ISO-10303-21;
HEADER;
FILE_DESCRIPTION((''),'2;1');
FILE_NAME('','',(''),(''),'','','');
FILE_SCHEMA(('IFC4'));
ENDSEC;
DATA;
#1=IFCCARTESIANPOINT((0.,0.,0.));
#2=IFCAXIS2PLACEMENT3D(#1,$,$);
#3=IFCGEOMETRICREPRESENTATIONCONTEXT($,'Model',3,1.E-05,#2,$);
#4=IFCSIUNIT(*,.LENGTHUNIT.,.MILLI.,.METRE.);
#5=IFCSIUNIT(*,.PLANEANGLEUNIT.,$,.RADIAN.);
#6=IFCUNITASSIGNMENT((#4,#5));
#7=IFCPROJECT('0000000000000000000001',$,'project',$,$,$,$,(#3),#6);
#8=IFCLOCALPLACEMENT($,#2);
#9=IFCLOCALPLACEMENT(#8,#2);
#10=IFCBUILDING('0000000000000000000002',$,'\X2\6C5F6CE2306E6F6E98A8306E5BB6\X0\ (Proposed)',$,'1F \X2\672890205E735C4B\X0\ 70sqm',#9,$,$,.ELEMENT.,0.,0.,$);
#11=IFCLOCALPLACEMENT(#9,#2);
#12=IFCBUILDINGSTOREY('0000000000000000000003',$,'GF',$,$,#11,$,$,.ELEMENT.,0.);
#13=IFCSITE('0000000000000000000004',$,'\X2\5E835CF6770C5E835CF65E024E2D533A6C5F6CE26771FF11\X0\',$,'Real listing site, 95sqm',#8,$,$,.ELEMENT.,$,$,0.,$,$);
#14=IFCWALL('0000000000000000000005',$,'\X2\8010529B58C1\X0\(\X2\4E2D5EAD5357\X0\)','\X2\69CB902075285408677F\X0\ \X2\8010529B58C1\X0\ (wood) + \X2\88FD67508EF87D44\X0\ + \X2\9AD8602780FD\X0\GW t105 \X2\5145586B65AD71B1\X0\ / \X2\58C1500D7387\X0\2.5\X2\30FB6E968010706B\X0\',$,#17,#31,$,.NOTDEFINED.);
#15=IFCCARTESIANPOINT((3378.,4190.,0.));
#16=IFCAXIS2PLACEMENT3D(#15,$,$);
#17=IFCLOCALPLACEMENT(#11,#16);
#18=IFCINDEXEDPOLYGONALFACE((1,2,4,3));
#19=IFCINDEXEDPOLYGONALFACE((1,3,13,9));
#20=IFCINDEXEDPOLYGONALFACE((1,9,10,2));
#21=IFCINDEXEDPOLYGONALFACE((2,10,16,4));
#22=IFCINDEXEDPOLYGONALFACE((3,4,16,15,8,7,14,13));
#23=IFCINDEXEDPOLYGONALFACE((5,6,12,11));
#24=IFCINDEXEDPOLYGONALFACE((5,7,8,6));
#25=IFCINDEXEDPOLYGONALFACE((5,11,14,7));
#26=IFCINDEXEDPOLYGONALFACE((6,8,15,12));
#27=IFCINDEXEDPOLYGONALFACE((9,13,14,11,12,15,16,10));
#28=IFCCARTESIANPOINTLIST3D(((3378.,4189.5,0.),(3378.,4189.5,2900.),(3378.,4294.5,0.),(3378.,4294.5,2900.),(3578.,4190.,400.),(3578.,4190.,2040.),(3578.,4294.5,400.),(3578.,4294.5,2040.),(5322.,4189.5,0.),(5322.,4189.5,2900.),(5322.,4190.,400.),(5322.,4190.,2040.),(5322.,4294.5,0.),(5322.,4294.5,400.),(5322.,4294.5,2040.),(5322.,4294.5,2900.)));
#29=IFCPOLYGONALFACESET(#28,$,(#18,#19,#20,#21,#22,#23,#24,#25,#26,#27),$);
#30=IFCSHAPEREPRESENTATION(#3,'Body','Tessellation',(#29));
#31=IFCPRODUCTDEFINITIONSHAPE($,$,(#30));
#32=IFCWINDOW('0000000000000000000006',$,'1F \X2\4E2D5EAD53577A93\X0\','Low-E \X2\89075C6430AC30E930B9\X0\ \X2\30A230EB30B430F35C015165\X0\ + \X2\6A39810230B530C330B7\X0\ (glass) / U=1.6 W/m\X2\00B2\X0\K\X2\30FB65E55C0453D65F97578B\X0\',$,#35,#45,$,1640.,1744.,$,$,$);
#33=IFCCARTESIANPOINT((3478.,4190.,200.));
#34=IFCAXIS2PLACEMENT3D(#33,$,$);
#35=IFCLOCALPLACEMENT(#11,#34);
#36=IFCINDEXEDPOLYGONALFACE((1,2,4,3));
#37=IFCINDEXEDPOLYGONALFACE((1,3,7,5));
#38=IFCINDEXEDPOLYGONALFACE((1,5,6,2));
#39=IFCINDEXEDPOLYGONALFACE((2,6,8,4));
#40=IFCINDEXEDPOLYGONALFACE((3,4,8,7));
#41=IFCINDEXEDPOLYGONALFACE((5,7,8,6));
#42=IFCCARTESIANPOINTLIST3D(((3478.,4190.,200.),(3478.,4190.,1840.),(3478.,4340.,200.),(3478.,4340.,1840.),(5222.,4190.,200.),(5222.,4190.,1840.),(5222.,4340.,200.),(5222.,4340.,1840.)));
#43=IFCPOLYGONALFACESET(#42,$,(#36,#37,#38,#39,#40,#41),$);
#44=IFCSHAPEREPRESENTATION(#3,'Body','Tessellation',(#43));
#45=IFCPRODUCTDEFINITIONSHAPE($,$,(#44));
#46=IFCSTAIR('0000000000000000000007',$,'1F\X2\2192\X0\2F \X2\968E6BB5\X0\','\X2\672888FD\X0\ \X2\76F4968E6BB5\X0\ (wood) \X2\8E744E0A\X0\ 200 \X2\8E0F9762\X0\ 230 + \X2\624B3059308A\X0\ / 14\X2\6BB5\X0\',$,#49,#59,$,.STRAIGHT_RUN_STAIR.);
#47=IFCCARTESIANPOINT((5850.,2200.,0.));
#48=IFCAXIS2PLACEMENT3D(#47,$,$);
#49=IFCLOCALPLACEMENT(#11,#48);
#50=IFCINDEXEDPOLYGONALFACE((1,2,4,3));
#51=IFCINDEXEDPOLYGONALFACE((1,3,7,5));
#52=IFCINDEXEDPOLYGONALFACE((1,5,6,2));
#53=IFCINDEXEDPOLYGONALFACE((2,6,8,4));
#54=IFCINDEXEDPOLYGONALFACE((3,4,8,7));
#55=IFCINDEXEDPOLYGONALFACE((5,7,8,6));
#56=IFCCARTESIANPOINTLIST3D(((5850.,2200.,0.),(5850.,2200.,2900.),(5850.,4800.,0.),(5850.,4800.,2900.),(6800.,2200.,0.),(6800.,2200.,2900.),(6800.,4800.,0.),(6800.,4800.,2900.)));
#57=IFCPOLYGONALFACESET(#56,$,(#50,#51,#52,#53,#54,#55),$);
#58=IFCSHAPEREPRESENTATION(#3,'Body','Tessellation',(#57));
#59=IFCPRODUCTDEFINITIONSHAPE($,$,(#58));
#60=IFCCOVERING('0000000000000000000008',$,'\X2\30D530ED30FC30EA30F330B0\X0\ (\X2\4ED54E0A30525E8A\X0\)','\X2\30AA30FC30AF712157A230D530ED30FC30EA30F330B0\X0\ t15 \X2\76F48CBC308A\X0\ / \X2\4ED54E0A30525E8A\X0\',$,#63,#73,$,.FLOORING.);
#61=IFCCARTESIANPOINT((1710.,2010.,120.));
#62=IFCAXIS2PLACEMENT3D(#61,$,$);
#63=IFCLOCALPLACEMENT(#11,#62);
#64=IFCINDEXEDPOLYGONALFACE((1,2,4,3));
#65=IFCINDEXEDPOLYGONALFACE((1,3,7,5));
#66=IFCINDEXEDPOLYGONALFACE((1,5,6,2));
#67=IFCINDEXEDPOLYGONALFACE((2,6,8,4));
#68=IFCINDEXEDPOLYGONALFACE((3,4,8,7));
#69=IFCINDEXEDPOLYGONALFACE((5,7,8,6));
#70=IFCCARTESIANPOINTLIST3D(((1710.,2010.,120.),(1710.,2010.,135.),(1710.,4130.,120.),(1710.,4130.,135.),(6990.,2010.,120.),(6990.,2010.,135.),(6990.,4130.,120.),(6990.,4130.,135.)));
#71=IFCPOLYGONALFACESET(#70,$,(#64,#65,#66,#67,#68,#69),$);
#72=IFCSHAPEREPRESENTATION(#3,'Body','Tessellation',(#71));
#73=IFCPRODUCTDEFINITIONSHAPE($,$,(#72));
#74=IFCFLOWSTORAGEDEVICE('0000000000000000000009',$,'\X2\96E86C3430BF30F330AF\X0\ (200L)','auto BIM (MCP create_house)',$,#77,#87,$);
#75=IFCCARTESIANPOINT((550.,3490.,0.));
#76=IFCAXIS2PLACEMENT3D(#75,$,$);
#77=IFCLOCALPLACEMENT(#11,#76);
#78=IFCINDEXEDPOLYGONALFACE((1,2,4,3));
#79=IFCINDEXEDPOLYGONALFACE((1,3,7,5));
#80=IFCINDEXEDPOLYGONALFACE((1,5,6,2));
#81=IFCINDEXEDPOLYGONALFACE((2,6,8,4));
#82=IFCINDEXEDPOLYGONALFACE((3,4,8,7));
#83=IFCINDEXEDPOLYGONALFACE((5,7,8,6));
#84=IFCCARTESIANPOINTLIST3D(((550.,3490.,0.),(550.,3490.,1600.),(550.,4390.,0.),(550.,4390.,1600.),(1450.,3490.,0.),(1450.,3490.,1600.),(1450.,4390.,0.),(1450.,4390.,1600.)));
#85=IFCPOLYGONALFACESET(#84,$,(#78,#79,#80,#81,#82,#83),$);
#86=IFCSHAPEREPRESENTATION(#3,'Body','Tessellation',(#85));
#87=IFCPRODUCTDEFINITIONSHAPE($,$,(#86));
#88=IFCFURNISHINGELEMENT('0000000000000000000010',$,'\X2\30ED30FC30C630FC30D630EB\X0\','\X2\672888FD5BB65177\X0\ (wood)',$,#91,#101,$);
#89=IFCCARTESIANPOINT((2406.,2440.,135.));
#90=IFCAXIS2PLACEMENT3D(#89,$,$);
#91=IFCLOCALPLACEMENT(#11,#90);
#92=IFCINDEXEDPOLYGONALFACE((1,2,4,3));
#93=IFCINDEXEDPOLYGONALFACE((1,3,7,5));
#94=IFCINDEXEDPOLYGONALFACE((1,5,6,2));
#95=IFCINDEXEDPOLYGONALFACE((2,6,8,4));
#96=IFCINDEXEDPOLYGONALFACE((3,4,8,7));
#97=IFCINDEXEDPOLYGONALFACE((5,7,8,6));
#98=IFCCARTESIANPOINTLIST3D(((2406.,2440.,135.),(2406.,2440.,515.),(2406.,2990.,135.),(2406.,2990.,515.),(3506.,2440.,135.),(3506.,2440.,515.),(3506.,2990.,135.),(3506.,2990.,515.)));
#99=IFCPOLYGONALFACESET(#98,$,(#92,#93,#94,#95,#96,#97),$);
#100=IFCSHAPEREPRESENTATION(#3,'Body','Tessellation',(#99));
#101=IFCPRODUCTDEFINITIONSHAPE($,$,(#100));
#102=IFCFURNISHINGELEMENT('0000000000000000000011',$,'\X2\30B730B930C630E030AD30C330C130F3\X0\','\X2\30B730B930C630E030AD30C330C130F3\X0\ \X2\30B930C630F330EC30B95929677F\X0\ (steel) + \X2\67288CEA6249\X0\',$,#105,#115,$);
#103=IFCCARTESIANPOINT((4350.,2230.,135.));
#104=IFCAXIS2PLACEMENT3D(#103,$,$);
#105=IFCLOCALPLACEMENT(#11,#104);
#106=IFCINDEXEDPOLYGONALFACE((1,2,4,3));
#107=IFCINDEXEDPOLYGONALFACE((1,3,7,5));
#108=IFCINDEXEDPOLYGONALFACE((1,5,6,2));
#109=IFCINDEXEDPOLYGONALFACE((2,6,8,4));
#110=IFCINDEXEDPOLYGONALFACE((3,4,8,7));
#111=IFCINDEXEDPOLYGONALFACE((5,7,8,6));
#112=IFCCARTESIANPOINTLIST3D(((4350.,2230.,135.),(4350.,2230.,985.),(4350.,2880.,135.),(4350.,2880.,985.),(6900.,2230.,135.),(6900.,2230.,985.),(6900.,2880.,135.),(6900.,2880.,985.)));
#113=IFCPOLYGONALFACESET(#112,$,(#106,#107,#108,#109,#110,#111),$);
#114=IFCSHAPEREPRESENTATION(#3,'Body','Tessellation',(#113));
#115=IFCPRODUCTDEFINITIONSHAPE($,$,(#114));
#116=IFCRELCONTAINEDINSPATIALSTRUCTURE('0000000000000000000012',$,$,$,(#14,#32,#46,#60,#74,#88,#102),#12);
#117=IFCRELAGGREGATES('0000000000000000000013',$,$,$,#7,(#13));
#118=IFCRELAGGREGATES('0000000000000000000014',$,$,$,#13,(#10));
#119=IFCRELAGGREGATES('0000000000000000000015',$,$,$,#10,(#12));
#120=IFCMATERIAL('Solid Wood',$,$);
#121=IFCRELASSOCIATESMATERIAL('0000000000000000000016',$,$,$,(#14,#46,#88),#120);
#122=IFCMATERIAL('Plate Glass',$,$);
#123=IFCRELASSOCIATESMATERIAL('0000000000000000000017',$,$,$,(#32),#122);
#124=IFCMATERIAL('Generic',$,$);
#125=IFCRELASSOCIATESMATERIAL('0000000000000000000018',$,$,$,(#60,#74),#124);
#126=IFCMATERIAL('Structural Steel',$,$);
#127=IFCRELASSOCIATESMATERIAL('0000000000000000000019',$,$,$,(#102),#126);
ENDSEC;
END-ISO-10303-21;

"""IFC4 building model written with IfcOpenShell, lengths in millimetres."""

from ifc_helpers import new_model, si_unit, frame, frame_2d, origin, place, context, project, spatial, rectangle, extrude, material, element, fill, save


model = new_model("IFC4")

# Units and contexts
model_context = context("Model", 3, precision=1e-05, world=origin())
ifc_project = project(units=[si_unit("LENGTHUNIT", "METRE", prefix="MILLI"), si_unit("PLANEANGLEUNIT", "RADIAN")], contexts=[model_context])

# Site, building, storey
site_placement = place(None, origin())
site = spatial("IfcSite", under=ifc_project, at=site_placement, Name="広島県広島市中区江波東１", ObjectType="Real listing site, 95sqm", CompositionType="ELEMENT", RefElevation=0.0)
building_placement = place(site_placement, origin())
building = spatial("IfcBuilding", under=site, at=building_placement, Name="江波の潮風の家 (Proposed)", ObjectType="1F 木造平屋 70sqm", CompositionType="ELEMENT", ElevationOfRefHeight=0.0, ElevationOfTerrain=0.0)
storey_placement = place(building_placement, origin())
storey = spatial("IfcBuildingStorey", under=building, at=storey_placement, Name="GF", CompositionType="ELEMENT", Elevation=0.0)

# Shared definitions
ifc_material_1 = material(Name="Solid Wood")

# Shared definitions
ifc_material_2 = material(Name="Plate Glass")

# Wall, opening, window
wall_1_placement = place(storey_placement, frame((3378.0, 4190.0, 0.0)))
wall_1 = element("IfcWall", 1, at=wall_1_placement, inside=storey, material=ifc_material_1, Name="耐力壁(中庭南)", Description="構造用合板 耐力壁 (wood) + 製材軸組 + 高性能GW t105 充填断熱 / 壁倍率2.5・準耐火", PredefinedType="NOTDEFINED", context=model_context, shape_type="SweptSolid", body=[
    extrude(rectangle(XDim=1944.0, YDim=105.0, at=frame_2d((972.0, 52.0))), frame((3378.0, 4190.0, 0.0)), (0.0, 0.0, 1.0), 2900.0),
])
opening_1_placement = place(storey_placement, frame((3478.0, 4190.0, 200.0)))
opening_1 = element("IfcOpeningElement", 2, at=opening_1_placement, cuts=wall_1, PredefinedType="NOTDEFINED", context=model_context, shape_type="SweptSolid", body=[
    extrude(rectangle(XDim=1744.0, YDim=150.0, at=frame_2d((872.0, 75.0))), frame((3478.0, 4190.0, 200.0)), (0.0, 0.0, 1.0), 1640.0),
])
window_1_placement = place(storey_placement, frame((3478.0, 4190.0, 200.0)))
window_1 = element("IfcWindow", 3, at=window_1_placement, inside=storey, material=ifc_material_2, Name="1F 中庭南窓", Description="Low-E 複層ガラス アルゴン封入 + 樹脂サッシ (glass) / U=1.6 W/m²K・日射取得型", OverallHeight=1640.0, OverallWidth=1744.0, context=model_context, shape_type="SweptSolid", body=[
    extrude(rectangle(XDim=1744.0, YDim=150.0, at=frame_2d((872.0, 75.0))), frame((3478.0, 4190.0, 200.0)), (0.0, 0.0, 1.0), 1640.0),
])
fill(opening_1, window_1)

# Stair
stair_placement = place(storey_placement, frame((5850.0, 2200.0, 0.0)))
element("IfcStair", 4, at=stair_placement, inside=storey, material=ifc_material_1, Name="1F→2F 階段", Description="木製 直階段 (wood) 蹴上 200 踏面 230 + 手すり / 14段", PredefinedType="STRAIGHT_RUN_STAIR", context=model_context, shape_type="SweptSolid", body=[
    extrude(rectangle(XDim=950.0, YDim=2600.0, at=frame_2d((475.0, 1300.0))), frame((5850.0, 2200.0, 0.0)), (0.0, 0.0, 1.0), 2900.0),
])

# Covering
ifc_material_3 = material(Name="Generic")
covering_placement = place(storey_placement, frame((1710.0, 2010.0, 120.0)))
element("IfcCovering", 5, at=covering_placement, inside=storey, material=ifc_material_3, Name="フローリング (仕上げ床)", Description="オーク無垢フローリング t15 直貼り / 仕上げ床", PredefinedType="FLOORING", context=model_context, shape_type="SweptSolid", body=[
    extrude(rectangle(XDim=5280.0, YDim=2120.0, at=frame_2d((2640.0, 1060.0))), frame((1710.0, 2010.0, 120.0)), (0.0, 0.0, 1.0), 15.0),
])

# Flow storage device
flow_storage_device_placement = place(storey_placement, frame((550.0, 3490.0, 0.0)))
element("IfcFlowStorageDevice", 6, at=flow_storage_device_placement, inside=storey, material=ifc_material_3, Name="雨水タンク (200L)", Description="auto BIM (MCP create_house)", context=model_context, shape_type="SweptSolid", body=[
    extrude(rectangle(XDim=900.0, YDim=900.0, at=frame_2d((450.0, 450.0))), frame((550.0, 3490.0, 0.0)), (0.0, 0.0, 1.0), 1600.0),
])

# Furnishing elements
furnishing_1_placement = place(storey_placement, frame((2406.0, 2440.0, 135.0)))
element("IfcFurnishingElement", 7, at=furnishing_1_placement, inside=storey, material=ifc_material_1, Name="ローテーブル", Description="木製家具 (wood)", context=model_context, shape_type="SweptSolid", body=[
    extrude(rectangle(XDim=1100.0, YDim=550.0, at=frame_2d((550.0, 275.0))), frame((2406.0, 2440.0, 135.0)), (0.0, 0.0, 1.0), 380.0),
])
ifc_material_4 = material(Name="Structural Steel")
furnishing_2_placement = place(storey_placement, frame((4350.0, 2230.0, 135.0)))
element("IfcFurnishingElement", 8, at=furnishing_2_placement, inside=storey, material=ifc_material_4, Name="システムキッチン", Description="システムキッチン ステンレス天板 (steel) + 木質扉", context=model_context, shape_type="SweptSolid", body=[
    extrude(rectangle(XDim=2550.0, YDim=650.0, at=frame_2d((1275.0, 325.0))), frame((4350.0, 2230.0, 135.0)), (0.0, 0.0, 1.0), 850.0),
])

save(model, "model.ifc")
